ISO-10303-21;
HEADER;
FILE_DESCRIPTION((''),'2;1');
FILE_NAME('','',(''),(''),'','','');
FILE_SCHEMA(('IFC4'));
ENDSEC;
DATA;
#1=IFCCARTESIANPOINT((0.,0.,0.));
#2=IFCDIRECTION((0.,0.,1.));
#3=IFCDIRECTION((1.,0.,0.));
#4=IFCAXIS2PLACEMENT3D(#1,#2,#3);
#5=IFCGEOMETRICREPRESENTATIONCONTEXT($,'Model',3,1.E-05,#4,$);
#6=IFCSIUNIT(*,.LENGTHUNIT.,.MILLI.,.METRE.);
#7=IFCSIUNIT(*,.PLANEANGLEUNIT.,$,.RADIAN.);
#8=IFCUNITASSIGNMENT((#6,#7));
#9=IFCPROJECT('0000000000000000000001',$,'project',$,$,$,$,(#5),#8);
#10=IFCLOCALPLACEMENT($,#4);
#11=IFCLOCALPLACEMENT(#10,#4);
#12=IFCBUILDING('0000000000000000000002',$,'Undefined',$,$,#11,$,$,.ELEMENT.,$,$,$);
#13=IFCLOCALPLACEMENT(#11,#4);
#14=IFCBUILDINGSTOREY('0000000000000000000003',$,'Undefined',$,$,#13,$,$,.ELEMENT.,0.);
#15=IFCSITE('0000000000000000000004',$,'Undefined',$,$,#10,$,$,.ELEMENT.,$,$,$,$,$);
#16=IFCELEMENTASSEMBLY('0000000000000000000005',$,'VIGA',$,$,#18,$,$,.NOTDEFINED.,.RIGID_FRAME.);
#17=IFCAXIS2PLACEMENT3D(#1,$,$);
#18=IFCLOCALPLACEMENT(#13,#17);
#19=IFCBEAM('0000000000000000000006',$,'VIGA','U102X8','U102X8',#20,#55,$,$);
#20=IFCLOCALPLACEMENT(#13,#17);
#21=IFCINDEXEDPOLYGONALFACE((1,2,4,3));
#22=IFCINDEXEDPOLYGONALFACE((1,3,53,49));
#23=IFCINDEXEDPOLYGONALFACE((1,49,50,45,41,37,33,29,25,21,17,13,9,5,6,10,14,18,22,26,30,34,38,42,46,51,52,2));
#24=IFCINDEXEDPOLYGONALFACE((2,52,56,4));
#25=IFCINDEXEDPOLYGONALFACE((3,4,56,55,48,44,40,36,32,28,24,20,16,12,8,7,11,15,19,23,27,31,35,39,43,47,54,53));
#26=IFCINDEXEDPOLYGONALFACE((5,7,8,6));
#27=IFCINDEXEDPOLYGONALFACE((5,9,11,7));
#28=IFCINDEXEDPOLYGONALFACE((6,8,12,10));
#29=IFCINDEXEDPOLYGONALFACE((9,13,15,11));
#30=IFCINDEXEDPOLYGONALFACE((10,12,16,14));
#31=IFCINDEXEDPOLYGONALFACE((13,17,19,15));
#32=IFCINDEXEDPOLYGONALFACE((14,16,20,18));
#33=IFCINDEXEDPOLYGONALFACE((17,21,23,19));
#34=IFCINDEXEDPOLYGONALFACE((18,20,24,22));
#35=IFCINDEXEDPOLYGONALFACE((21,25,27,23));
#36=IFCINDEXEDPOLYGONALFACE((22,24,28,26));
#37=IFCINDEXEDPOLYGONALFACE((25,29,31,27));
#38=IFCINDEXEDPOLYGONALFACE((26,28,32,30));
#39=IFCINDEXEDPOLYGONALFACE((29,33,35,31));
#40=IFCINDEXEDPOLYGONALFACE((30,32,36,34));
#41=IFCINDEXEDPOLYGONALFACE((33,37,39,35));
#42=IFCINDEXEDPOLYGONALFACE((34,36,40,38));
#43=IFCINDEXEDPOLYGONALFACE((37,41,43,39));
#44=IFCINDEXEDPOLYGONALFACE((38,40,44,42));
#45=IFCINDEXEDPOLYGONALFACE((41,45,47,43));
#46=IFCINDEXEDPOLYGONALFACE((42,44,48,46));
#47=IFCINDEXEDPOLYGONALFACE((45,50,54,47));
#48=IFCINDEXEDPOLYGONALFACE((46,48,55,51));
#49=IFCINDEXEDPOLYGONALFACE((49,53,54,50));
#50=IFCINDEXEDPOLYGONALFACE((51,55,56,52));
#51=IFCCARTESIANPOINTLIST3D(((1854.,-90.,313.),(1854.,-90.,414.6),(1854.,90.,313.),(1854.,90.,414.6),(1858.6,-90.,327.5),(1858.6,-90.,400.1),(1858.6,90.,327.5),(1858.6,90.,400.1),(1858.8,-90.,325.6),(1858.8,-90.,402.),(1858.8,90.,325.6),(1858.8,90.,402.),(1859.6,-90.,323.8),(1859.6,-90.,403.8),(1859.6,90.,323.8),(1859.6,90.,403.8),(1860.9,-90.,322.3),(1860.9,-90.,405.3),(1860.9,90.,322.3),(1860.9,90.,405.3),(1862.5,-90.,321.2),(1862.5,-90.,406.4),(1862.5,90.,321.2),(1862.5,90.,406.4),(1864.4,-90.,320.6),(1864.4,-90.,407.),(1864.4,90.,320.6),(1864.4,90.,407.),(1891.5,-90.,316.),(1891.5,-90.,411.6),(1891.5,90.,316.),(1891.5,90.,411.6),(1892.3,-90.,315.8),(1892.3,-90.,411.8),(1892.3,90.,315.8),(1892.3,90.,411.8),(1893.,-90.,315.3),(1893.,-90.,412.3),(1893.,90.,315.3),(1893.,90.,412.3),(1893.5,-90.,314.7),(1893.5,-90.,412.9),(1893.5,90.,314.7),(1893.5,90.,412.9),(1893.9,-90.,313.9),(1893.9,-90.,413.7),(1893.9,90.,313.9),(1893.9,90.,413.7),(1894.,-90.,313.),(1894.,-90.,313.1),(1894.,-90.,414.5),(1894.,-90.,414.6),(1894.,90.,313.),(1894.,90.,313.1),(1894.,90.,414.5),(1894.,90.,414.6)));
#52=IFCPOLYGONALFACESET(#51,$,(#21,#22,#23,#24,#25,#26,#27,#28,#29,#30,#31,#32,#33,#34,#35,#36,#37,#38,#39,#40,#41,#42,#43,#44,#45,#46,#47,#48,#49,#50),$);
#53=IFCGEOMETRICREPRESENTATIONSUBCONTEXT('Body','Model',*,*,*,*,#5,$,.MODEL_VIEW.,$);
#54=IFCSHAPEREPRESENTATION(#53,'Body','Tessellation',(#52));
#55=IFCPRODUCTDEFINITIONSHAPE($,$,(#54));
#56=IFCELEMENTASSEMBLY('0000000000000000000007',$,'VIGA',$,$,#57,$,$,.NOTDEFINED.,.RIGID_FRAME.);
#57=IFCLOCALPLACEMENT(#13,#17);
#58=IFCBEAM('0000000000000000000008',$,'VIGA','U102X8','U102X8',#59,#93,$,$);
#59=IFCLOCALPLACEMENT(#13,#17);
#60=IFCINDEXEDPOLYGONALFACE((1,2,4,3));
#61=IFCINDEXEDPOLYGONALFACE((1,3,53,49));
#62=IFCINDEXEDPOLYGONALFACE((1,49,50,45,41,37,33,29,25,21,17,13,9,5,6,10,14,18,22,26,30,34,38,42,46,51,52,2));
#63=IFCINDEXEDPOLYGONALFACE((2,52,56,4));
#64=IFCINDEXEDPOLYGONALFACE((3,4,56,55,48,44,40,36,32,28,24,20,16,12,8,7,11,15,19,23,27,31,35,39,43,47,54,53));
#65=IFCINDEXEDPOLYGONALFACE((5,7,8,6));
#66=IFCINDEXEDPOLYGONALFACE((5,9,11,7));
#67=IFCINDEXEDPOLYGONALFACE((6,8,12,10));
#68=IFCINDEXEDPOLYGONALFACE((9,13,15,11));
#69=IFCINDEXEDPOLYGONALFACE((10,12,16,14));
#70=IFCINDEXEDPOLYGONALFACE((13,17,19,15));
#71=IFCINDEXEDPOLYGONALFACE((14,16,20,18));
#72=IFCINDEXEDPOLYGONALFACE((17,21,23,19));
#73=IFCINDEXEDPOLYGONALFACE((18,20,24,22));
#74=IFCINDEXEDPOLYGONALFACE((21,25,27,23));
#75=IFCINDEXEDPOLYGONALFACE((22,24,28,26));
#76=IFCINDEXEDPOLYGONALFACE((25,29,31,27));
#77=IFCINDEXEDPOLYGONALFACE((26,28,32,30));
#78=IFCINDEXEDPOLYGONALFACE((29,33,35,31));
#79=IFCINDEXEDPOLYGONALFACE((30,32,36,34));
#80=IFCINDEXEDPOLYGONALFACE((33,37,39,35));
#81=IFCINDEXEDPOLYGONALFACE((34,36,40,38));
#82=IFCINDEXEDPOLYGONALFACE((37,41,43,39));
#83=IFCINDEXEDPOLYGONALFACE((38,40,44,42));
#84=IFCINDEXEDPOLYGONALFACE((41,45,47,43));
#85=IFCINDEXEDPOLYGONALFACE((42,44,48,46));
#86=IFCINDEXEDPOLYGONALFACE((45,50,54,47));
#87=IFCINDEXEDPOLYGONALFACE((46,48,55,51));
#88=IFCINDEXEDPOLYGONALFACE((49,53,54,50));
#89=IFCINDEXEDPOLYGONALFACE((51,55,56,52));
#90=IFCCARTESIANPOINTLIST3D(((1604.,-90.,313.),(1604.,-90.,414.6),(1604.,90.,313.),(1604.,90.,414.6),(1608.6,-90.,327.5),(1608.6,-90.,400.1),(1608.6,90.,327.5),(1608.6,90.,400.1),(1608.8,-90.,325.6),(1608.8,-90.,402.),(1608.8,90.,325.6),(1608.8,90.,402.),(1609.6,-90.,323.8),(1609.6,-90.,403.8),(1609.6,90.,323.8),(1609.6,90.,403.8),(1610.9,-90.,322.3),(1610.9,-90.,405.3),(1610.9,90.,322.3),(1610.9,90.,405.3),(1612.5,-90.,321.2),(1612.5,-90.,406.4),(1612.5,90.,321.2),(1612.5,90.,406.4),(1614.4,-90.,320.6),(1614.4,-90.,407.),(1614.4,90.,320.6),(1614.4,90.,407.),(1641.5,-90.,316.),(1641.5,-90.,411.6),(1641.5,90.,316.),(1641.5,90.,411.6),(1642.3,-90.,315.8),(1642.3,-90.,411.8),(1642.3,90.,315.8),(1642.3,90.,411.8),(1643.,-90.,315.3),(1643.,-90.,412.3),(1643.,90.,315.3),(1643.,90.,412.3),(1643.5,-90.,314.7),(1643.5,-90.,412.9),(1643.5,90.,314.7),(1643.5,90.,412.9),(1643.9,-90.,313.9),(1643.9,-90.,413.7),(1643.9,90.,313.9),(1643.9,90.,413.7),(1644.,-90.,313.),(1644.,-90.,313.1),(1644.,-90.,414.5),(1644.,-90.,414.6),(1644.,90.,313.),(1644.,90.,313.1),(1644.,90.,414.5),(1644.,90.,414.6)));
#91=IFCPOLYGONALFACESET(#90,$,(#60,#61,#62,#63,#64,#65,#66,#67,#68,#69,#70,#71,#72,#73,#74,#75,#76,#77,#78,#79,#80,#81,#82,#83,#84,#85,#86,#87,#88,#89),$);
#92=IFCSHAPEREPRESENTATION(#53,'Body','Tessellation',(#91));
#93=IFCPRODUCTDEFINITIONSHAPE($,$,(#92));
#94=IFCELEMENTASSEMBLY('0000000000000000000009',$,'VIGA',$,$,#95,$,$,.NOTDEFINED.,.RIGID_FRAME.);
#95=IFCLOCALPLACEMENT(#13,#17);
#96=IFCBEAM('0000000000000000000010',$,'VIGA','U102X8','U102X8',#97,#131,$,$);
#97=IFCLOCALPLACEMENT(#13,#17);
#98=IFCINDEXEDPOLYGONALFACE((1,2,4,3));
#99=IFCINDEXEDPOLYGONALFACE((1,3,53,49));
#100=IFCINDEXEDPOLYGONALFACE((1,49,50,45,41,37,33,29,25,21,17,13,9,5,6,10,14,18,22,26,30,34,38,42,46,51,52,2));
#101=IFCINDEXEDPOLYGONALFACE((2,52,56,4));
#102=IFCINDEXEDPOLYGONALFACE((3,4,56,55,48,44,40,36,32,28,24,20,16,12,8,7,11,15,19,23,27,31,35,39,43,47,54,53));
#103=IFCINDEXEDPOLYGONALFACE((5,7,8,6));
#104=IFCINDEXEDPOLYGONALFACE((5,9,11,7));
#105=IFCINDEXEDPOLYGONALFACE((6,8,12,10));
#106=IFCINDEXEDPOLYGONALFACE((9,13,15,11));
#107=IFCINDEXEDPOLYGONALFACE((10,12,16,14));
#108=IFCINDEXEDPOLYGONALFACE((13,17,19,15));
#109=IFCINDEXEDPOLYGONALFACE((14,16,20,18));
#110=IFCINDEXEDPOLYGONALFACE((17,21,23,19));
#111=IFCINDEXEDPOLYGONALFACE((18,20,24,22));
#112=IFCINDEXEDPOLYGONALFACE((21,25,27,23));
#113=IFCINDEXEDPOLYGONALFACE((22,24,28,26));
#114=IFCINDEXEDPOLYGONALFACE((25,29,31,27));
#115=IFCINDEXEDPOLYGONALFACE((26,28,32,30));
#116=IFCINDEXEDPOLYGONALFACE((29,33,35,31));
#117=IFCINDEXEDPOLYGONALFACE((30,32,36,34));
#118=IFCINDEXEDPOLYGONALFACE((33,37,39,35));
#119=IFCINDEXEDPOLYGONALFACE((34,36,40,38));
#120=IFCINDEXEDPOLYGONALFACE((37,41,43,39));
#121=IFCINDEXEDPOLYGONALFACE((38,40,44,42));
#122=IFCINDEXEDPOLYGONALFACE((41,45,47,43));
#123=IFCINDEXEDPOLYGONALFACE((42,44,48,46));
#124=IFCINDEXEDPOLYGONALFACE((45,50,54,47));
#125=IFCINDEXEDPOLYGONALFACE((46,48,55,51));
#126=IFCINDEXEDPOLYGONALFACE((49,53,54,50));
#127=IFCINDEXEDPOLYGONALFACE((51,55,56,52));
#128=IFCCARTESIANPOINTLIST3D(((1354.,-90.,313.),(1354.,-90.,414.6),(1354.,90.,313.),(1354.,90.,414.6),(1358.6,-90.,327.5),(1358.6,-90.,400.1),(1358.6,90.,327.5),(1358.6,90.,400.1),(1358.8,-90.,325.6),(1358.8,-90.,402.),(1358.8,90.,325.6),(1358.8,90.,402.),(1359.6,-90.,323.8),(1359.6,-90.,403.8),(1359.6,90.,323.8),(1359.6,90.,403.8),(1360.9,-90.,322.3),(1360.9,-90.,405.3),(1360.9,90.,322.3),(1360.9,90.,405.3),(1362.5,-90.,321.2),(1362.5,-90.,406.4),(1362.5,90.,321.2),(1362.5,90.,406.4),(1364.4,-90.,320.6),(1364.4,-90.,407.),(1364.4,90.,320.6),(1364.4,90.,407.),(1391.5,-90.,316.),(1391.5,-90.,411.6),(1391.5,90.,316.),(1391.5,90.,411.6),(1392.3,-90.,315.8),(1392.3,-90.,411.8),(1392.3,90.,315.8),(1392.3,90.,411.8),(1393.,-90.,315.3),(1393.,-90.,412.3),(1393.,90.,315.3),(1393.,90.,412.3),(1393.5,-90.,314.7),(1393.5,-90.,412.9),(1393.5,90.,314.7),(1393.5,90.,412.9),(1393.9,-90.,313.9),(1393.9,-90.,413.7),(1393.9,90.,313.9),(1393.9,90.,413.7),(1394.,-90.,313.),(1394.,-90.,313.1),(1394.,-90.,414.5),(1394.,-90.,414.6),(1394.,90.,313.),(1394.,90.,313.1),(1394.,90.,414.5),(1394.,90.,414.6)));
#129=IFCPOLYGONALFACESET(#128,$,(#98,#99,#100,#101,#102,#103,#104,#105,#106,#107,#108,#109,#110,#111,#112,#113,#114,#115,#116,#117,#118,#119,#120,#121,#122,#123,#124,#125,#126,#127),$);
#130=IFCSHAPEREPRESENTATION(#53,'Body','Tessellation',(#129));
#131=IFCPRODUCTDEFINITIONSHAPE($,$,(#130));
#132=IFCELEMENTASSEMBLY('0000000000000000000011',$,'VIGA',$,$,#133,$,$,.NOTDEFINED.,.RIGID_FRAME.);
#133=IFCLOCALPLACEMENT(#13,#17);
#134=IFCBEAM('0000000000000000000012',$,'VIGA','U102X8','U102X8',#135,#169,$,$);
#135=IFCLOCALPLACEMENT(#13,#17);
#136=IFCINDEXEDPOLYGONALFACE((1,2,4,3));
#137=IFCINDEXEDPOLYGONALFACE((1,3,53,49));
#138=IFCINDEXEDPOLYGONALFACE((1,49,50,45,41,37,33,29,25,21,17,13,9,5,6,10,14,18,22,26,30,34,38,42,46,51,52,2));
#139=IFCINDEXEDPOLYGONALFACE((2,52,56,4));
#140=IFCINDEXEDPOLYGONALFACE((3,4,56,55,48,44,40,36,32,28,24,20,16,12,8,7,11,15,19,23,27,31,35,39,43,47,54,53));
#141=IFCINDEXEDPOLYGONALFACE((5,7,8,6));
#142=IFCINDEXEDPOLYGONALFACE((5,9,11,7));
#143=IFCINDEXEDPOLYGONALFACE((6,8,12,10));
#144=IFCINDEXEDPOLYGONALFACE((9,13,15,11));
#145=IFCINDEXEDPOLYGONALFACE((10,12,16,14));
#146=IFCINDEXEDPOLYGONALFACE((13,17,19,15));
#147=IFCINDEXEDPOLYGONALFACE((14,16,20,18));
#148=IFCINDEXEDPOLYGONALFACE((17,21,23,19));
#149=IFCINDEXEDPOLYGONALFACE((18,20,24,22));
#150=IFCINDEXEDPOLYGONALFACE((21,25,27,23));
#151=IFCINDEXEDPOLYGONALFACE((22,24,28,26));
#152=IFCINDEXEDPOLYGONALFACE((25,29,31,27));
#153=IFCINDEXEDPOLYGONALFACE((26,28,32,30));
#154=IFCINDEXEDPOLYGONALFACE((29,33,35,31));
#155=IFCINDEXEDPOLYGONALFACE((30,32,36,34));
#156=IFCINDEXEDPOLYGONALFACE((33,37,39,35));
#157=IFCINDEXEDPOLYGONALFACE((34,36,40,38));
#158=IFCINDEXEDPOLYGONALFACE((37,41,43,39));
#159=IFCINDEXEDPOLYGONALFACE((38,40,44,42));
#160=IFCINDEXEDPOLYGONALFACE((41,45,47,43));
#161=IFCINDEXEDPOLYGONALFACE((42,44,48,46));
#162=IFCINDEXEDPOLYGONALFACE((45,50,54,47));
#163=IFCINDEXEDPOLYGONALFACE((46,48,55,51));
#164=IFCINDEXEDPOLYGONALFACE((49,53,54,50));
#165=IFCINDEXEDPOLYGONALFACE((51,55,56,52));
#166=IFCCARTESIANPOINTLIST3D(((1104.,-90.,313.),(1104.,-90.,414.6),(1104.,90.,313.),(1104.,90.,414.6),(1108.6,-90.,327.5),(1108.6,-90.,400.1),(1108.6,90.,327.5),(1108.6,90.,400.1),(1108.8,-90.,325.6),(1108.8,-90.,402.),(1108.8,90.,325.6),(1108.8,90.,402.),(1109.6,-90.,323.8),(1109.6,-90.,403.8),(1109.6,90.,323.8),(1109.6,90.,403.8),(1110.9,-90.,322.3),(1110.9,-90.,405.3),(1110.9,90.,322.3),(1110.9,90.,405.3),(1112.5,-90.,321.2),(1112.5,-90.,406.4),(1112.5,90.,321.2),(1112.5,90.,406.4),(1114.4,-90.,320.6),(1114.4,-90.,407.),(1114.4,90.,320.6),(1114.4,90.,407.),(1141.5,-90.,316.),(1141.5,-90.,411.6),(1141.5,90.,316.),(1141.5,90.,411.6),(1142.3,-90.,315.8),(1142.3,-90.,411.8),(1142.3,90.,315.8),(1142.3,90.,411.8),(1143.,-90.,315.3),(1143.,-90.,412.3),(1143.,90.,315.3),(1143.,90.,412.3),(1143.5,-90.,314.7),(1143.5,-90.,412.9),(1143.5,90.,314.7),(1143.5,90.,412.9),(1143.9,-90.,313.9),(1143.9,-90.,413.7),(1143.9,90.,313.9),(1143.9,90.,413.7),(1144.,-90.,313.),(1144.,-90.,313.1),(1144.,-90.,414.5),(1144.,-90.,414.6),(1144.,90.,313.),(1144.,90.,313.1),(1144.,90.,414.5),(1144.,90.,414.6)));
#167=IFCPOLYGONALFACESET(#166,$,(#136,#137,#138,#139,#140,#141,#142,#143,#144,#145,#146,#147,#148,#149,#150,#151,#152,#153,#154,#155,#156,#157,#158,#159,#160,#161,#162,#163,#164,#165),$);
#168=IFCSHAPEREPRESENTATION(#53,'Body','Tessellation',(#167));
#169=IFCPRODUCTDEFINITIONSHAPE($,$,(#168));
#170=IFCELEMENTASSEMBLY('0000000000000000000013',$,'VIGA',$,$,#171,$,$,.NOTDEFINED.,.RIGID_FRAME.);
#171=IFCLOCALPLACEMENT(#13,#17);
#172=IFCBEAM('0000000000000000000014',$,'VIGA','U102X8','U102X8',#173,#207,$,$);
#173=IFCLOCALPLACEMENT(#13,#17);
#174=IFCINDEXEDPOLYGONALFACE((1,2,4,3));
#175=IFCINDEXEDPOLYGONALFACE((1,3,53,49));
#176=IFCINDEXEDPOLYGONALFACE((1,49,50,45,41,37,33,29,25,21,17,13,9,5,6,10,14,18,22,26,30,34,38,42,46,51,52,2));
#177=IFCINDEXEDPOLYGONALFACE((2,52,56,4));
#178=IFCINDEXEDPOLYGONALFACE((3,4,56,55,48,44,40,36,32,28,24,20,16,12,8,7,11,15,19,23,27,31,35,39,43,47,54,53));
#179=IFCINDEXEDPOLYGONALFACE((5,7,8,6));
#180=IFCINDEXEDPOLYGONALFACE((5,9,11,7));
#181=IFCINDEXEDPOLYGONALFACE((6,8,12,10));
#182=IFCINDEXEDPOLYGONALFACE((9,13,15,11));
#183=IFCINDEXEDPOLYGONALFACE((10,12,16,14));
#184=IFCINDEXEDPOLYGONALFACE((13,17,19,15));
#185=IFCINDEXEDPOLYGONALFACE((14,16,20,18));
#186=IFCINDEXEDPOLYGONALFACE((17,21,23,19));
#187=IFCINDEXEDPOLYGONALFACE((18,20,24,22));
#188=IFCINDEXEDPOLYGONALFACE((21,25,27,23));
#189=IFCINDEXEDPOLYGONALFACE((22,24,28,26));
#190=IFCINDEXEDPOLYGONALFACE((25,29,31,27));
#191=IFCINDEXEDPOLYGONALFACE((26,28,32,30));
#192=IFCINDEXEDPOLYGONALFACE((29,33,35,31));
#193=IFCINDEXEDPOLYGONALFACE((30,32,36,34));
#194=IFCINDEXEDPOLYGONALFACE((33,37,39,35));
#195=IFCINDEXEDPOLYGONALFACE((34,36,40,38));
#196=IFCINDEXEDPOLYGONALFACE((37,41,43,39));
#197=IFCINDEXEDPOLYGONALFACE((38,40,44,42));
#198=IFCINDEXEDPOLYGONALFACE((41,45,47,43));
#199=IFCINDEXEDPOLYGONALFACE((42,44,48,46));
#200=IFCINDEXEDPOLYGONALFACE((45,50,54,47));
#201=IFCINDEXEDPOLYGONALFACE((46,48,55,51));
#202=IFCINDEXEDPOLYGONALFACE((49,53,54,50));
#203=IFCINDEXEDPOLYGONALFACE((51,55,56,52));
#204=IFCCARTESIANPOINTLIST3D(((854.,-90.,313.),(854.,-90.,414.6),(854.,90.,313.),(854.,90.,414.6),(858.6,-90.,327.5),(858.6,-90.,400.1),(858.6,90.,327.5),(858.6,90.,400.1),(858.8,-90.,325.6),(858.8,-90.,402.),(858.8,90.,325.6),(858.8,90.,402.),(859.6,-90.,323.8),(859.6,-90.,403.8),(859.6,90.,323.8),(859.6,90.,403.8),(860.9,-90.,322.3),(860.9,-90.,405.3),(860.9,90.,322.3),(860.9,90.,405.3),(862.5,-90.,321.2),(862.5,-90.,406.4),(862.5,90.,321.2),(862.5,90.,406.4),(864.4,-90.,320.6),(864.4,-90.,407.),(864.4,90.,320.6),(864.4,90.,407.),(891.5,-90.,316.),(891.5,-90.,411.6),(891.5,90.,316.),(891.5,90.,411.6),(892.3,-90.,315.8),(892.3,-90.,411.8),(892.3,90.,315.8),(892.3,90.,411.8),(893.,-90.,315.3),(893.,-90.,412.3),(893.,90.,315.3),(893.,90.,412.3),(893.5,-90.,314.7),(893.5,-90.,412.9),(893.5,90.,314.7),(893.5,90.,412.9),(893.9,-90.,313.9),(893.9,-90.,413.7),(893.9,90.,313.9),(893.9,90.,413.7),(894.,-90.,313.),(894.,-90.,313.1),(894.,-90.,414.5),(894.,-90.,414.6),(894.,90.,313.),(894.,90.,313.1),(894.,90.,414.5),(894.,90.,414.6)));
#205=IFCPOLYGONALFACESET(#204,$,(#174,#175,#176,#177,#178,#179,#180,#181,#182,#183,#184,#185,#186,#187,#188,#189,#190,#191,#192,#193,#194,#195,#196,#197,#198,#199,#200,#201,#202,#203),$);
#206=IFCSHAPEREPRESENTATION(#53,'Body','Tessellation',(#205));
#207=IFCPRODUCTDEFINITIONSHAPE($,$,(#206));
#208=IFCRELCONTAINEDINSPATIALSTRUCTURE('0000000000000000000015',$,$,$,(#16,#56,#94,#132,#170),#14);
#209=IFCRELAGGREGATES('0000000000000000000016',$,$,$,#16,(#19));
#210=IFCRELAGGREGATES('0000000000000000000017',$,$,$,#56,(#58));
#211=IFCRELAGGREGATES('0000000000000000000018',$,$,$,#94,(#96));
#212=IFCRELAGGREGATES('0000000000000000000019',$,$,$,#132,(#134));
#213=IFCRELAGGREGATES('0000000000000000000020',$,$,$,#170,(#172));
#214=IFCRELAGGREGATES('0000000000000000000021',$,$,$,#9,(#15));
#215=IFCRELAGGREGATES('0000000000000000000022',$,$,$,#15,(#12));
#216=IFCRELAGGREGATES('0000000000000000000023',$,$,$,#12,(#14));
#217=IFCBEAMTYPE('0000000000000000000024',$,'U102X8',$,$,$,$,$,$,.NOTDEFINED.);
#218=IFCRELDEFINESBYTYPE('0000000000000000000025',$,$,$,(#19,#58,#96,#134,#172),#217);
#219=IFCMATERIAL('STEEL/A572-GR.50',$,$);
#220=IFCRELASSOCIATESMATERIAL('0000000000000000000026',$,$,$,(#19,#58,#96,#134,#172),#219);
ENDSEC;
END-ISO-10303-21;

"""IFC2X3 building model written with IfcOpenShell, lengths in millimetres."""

from ifc_helpers import new_model, si_unit, frame, origin_with_axes, origin_2d_with_axis, place, context, subcontext, project, spatial, u_section, extrude, material, type_object, element, aggregate, save


model = new_model("IFC2X3")

# Units and contexts
model_context = context("Model", 3, precision=1e-05, world=origin_with_axes())
body_context = subcontext(model_context, "Body", "Model", "MODEL_VIEW")
ifc_project = project(units=[si_unit("LENGTHUNIT", "METRE", prefix="MILLI"), si_unit("PLANEANGLEUNIT", "RADIAN")], contexts=[model_context])

# Site, building, storey
site_placement = place(None, origin_with_axes())
site = spatial("IfcSite", under=ifc_project, at=site_placement, Name="Undefined", CompositionType="ELEMENT")
building_placement = place(site_placement, origin_with_axes())
building = spatial("IfcBuilding", under=site, at=building_placement, Name="Undefined", CompositionType="ELEMENT")
storey_placement = place(building_placement, origin_with_axes())
storey = spatial("IfcBuildingStorey", under=building, at=storey_placement, Name="Undefined", CompositionType="ELEMENT", Elevation=0.0)

# Element assemblies, beams
ifc_material_1 = material(Name="STEEL/A572-GR.50")
beam_type_1 = type_object("IfcBeamType", Name="U102X8", PredefinedType="NOTDEFINED")
assembly_1_placement = place(storey_placement, origin_with_axes())
assembly_1 = element("IfcElementAssembly", 1, at=assembly_1_placement, inside=storey, Name="VIGA", AssemblyPlace="NOTDEFINED", PredefinedType="RIGID_FRAME")
beam_1_placement = place(assembly_1_placement, frame((1874.0, -90.0, 363.8), z_axis=(0.0, 0.0, 1.0), x_axis=(0.0, 1.0, 0.0)))
beam_1 = element("IfcBeam", 2, at=beam_1_placement, type_object=beam_type_1, material=ifc_material_1, Name="VIGA", Description="U102X8", ObjectType="U102X8", context=body_context, shape_type="SweptSolid", body=[
    extrude(u_section(Depth=101.6, FlangeWidth=40.0, WebThickness=4.6, FlangeThickness=6.0, FilletRadius=7.0, EdgeRadius=3.0, FlangeSlope=0.16839, at=origin_2d_with_axis()), frame((180.0, 0.0, 0.0), z_axis=(-1.0, 0.0, 0.0), x_axis=(0.0, -1.0, 0.0)), (0.0, 0.0, 1.0), 180.0),
])
aggregate(assembly_1, [beam_1])
assembly_2_placement = place(storey_placement, origin_with_axes())
assembly_2 = element("IfcElementAssembly", 3, at=assembly_2_placement, inside=storey, Name="VIGA", AssemblyPlace="NOTDEFINED", PredefinedType="RIGID_FRAME")
beam_2_placement = place(assembly_2_placement, frame((1624.0, -90.0, 363.8), z_axis=(0.0, 0.0, 1.0), x_axis=(0.0, 1.0, 0.0)))
beam_2 = element("IfcBeam", 4, at=beam_2_placement, type_object=beam_type_1, material=ifc_material_1, Name="VIGA", Description="U102X8", ObjectType="U102X8", context=body_context, shape_type="SweptSolid", body=[
    extrude(u_section(Depth=101.6, FlangeWidth=40.0, WebThickness=4.6, FlangeThickness=6.0, FilletRadius=7.0, EdgeRadius=3.0, FlangeSlope=0.16839, at=origin_2d_with_axis()), frame((180.0, 0.0, 0.0), z_axis=(-1.0, 0.0, 0.0), x_axis=(0.0, -1.0, 0.0)), (0.0, 0.0, 1.0), 180.0),
])
aggregate(assembly_2, [beam_2])
assembly_3_placement = place(storey_placement, origin_with_axes())
assembly_3 = element("IfcElementAssembly", 5, at=assembly_3_placement, inside=storey, Name="VIGA", AssemblyPlace="NOTDEFINED", PredefinedType="RIGID_FRAME")
beam_3_placement = place(assembly_3_placement, frame((1374.0, -90.0, 363.8), z_axis=(0.0, 0.0, 1.0), x_axis=(0.0, 1.0, 0.0)))
beam_3 = element("IfcBeam", 6, at=beam_3_placement, type_object=beam_type_1, material=ifc_material_1, Name="VIGA", Description="U102X8", ObjectType="U102X8", context=body_context, shape_type="SweptSolid", body=[
    extrude(u_section(Depth=101.6, FlangeWidth=40.0, WebThickness=4.6, FlangeThickness=6.0, FilletRadius=7.0, EdgeRadius=3.0, FlangeSlope=0.16839, at=origin_2d_with_axis()), frame((180.0, 0.0, 0.0), z_axis=(-1.0, 0.0, 0.0), x_axis=(0.0, -1.0, 0.0)), (0.0, 0.0, 1.0), 180.0),
])
aggregate(assembly_3, [beam_3])
assembly_4_placement = place(storey_placement, origin_with_axes())
assembly_4 = element("IfcElementAssembly", 7, at=assembly_4_placement, inside=storey, Name="VIGA", AssemblyPlace="NOTDEFINED", PredefinedType="RIGID_FRAME")
beam_4_placement = place(assembly_4_placement, frame((1124.0, -90.0, 363.8), z_axis=(0.0, 0.0, 1.0), x_axis=(0.0, 1.0, 0.0)))
beam_4 = element("IfcBeam", 8, at=beam_4_placement, type_object=beam_type_1, material=ifc_material_1, Name="VIGA", Description="U102X8", ObjectType="U102X8", context=body_context, shape_type="SweptSolid", body=[
    extrude(u_section(Depth=101.6, FlangeWidth=40.0, WebThickness=4.6, FlangeThickness=6.0, FilletRadius=7.0, EdgeRadius=3.0, FlangeSlope=0.16839, at=origin_2d_with_axis()), frame((180.0, 0.0, 0.0), z_axis=(-1.0, 0.0, 0.0), x_axis=(0.0, -1.0, 0.0)), (0.0, 0.0, 1.0), 180.0),
])
aggregate(assembly_4, [beam_4])
assembly_5_placement = place(storey_placement, origin_with_axes())
assembly_5 = element("IfcElementAssembly", 9, at=assembly_5_placement, inside=storey, Name="VIGA", AssemblyPlace="NOTDEFINED", PredefinedType="RIGID_FRAME")
beam_5_placement = place(assembly_5_placement, frame((874.0, -90.0, 363.8), z_axis=(0.0, 0.0, 1.0), x_axis=(0.0, 1.0, 0.0)))
beam_5 = element("IfcBeam", 10, at=beam_5_placement, type_object=beam_type_1, material=ifc_material_1, Name="VIGA", Description="U102X8", ObjectType="U102X8", context=body_context, shape_type="SweptSolid", body=[
    extrude(u_section(Depth=101.6, FlangeWidth=40.0, WebThickness=4.6, FlangeThickness=6.0, FilletRadius=7.0, EdgeRadius=3.0, FlangeSlope=0.16839, at=origin_2d_with_axis()), frame((180.0, 0.0, 0.0), z_axis=(-1.0, 0.0, 0.0), x_axis=(0.0, -1.0, 0.0)), (0.0, 0.0, 1.0), 180.0),
])
aggregate(assembly_5, [beam_5])

save(model, "model.ifc")
